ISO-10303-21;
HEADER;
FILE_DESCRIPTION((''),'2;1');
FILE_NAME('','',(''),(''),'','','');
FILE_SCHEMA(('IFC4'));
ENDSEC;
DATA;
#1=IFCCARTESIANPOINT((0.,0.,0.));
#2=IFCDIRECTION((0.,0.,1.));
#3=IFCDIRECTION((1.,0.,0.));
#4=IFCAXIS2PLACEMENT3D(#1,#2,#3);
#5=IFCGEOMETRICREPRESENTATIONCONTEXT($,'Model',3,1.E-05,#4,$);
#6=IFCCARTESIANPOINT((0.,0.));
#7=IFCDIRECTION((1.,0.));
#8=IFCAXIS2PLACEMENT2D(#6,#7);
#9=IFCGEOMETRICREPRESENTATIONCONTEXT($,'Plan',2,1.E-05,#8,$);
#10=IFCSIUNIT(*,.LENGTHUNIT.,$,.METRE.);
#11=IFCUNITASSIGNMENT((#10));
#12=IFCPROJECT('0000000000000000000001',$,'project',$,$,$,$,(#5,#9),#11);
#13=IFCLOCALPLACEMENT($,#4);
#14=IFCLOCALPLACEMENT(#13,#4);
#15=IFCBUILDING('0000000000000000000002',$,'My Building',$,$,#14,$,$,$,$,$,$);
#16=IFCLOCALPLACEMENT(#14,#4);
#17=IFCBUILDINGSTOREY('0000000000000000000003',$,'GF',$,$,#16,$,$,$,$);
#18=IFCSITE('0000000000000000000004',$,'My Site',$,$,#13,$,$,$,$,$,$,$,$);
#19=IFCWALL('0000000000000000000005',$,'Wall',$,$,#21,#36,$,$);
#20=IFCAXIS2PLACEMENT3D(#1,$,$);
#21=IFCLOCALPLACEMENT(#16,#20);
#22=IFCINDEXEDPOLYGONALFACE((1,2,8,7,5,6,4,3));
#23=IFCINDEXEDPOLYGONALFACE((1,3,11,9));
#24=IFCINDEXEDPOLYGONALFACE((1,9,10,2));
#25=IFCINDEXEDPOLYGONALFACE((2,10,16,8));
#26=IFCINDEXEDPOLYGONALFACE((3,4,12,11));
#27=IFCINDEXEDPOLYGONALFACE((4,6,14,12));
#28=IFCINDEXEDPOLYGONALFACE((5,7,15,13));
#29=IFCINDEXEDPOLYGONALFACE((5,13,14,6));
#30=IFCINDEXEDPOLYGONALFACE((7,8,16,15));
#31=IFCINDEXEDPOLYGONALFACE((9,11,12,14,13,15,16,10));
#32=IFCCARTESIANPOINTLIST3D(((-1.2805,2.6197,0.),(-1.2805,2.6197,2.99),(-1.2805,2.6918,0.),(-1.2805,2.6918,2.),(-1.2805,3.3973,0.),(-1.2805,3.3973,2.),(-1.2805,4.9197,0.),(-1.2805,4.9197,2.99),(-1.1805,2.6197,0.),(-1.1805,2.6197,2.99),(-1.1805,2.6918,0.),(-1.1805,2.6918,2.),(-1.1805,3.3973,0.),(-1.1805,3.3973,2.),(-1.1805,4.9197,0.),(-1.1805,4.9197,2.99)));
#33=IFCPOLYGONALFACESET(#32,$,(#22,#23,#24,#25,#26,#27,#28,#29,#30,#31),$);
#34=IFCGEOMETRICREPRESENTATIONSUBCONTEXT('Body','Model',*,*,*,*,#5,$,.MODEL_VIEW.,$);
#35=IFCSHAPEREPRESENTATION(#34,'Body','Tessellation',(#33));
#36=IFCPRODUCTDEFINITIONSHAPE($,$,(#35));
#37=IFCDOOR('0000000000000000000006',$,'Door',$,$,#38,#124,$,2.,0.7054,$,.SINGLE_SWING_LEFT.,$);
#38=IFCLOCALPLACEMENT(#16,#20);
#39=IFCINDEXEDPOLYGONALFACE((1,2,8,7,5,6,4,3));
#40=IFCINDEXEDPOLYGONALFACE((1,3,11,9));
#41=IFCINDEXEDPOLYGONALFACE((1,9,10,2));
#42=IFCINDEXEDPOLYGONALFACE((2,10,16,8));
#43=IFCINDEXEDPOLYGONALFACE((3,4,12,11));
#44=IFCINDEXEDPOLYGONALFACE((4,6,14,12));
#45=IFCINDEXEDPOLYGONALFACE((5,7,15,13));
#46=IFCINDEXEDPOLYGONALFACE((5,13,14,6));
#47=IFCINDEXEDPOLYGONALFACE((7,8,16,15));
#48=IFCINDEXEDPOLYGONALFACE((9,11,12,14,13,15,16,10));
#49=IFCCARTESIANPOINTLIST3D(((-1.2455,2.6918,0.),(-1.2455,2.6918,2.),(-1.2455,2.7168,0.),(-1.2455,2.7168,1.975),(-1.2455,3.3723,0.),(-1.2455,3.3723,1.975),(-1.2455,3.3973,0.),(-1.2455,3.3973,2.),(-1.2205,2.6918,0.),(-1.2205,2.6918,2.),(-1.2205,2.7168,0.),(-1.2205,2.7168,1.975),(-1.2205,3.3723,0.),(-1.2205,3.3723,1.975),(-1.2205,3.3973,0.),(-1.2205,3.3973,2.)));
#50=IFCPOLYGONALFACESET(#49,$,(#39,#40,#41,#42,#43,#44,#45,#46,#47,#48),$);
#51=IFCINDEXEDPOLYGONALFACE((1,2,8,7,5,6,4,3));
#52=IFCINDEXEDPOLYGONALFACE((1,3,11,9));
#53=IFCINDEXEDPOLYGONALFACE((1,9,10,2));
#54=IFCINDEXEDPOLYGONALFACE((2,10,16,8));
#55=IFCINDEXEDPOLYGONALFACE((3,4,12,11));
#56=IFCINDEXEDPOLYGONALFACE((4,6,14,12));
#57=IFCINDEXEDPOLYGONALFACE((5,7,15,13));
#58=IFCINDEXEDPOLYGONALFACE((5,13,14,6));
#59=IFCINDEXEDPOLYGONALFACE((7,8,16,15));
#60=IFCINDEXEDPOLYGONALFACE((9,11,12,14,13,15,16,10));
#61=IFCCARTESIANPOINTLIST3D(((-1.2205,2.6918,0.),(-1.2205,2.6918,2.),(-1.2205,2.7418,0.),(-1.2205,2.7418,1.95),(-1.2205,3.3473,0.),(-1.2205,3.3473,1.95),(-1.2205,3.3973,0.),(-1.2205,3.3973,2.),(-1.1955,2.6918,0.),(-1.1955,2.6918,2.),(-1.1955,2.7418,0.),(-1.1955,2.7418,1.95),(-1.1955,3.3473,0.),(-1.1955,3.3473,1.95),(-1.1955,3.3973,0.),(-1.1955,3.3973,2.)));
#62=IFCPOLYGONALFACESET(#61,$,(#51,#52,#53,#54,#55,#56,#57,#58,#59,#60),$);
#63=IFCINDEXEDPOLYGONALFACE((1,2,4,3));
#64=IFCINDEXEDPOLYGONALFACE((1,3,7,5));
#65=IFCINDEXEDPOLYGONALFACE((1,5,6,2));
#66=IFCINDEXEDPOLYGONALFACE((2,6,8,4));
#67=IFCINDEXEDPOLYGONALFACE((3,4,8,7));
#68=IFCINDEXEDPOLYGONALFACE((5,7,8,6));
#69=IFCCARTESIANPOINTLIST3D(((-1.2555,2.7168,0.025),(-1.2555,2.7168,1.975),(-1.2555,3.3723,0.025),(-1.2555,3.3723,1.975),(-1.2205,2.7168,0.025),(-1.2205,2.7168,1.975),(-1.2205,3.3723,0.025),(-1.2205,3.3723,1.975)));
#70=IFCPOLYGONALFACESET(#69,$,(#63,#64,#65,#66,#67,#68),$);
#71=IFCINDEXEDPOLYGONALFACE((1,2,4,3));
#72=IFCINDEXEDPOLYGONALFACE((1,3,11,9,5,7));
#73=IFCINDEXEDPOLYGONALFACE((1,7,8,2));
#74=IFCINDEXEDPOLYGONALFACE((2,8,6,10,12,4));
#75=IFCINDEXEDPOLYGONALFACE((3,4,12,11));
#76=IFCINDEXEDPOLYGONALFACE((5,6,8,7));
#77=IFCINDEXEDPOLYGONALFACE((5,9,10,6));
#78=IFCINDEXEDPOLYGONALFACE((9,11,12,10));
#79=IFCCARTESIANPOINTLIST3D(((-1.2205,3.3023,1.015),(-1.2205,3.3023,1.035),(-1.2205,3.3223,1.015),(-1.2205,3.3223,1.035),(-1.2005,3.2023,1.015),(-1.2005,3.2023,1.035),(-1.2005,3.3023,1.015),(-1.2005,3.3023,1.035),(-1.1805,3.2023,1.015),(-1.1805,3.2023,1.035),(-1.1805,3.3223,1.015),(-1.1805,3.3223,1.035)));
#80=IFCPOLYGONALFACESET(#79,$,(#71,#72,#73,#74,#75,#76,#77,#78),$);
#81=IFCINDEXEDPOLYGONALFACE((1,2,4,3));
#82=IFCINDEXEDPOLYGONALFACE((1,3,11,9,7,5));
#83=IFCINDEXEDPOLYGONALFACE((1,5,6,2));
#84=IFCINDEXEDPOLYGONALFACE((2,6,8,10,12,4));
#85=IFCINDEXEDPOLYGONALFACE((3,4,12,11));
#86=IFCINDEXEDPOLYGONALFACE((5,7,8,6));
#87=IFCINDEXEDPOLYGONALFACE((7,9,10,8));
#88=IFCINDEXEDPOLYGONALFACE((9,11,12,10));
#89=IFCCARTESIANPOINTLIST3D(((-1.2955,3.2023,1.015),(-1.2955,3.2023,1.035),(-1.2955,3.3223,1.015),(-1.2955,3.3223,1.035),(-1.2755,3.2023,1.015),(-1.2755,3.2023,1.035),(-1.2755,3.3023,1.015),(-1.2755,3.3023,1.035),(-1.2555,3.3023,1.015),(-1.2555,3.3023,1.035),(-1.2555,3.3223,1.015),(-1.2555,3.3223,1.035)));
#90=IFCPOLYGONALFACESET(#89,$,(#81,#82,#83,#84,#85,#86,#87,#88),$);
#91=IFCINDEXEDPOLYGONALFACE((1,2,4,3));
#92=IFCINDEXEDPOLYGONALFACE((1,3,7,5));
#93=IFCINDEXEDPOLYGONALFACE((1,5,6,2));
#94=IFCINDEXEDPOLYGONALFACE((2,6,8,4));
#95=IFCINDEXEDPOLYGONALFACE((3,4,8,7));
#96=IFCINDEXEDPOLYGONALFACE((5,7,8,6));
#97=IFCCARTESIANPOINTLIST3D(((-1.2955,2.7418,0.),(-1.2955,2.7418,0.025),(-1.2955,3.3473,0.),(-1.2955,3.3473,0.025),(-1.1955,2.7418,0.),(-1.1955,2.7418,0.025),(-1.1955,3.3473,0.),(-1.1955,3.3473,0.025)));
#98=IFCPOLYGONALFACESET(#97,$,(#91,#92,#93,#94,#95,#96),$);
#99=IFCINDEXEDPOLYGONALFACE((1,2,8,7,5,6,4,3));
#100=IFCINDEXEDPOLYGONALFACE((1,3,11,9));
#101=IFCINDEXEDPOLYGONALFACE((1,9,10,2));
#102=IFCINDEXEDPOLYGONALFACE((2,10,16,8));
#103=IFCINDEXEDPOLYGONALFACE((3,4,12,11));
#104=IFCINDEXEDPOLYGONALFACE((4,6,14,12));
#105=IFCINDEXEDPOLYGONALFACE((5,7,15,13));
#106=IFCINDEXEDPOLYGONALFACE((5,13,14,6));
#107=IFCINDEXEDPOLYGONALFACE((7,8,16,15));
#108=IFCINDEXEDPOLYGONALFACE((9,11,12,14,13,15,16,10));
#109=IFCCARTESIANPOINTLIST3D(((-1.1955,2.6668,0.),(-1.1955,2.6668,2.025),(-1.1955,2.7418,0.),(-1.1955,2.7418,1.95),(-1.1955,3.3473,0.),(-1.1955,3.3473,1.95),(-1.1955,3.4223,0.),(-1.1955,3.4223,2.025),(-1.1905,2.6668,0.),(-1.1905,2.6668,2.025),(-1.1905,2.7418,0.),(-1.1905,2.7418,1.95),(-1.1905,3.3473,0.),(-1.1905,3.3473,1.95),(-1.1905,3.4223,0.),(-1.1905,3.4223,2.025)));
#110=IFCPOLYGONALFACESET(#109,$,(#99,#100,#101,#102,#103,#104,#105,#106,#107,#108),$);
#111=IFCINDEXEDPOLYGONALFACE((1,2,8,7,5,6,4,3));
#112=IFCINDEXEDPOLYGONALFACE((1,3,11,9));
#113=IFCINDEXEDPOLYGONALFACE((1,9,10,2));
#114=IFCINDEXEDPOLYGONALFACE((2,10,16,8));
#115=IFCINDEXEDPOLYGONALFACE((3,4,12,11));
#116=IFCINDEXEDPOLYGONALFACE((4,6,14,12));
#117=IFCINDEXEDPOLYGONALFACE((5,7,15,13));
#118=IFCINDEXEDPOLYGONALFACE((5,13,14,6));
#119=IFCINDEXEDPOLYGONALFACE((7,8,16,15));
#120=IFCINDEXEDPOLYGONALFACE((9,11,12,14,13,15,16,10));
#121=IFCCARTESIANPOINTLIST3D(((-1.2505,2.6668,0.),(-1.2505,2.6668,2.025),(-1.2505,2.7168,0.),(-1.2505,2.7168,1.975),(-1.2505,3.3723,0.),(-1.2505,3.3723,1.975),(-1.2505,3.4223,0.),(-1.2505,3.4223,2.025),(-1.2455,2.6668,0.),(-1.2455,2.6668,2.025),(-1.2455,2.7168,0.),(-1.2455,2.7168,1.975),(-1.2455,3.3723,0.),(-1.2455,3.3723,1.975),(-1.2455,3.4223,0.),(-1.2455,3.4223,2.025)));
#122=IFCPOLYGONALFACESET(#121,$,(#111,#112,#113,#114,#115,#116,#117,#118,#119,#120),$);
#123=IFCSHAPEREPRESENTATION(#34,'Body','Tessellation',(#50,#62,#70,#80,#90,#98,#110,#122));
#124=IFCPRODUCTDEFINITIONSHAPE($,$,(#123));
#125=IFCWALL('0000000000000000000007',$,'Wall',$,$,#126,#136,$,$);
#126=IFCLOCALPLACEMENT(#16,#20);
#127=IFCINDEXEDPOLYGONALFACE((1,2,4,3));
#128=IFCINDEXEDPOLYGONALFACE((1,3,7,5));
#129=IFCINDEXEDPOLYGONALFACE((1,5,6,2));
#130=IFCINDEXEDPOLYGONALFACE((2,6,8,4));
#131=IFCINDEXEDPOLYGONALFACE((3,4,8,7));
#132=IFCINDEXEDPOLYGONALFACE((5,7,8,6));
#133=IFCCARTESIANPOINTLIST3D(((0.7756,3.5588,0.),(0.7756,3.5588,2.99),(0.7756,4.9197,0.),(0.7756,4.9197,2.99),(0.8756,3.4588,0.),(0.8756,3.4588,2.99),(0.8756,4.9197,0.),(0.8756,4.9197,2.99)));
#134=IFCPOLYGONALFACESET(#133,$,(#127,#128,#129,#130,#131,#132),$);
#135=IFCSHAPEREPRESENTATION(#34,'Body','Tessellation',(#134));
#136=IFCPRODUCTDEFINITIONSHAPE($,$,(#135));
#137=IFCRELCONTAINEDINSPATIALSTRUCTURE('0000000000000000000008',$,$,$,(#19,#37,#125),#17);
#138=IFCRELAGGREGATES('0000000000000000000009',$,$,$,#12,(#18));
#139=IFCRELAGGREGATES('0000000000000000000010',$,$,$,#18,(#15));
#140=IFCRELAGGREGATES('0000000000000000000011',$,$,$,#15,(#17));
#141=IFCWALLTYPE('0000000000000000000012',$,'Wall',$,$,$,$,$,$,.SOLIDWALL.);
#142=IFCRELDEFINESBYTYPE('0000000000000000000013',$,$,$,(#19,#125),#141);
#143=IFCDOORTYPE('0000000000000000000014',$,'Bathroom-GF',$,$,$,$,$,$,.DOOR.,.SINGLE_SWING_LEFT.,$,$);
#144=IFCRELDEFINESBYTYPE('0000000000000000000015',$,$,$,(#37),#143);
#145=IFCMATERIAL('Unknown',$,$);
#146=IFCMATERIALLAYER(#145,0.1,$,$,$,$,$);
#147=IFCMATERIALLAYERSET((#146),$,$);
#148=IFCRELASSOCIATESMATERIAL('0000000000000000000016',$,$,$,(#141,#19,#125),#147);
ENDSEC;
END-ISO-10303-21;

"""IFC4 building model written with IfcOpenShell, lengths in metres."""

from ifc_helpers import new_model, entity, si_unit, frame, origin_with_axes, origin_2d_with_axis, place, context, subcontext, project, spatial, line, indexed_curve, outline, extrude, shape, source, transform, mapped, material, layer, layer_set, layer_usage, type_object, type_shapes, element, fill, save


model = new_model("IFC4")

# Units and contexts
model_context = context("Model", 3, precision=1e-05, world=origin_with_axes())
plan_context = context("Plan", 2, precision=1e-05, world=origin_2d_with_axis())
body_context_1 = subcontext(model_context, "Body", "Model", "MODEL_VIEW")
body_context_2 = subcontext(plan_context, "Body", "Plan", "PLAN_VIEW")
ifc_project = project(units=[si_unit("LENGTHUNIT", "METRE")], contexts=[model_context, plan_context])

# Site, building, storey
site_placement = place(None, origin_with_axes())
site = spatial("IfcSite", under=ifc_project, at=site_placement, Name="My Site")
building_placement = place(site_placement, origin_with_axes())
building = spatial("IfcBuilding", under=site, at=building_placement, Name="My Building")
storey_placement = place(building_placement, origin_with_axes())
storey = spatial("IfcBuildingStorey", under=building, at=storey_placement, Name="GF")

# Shared definitions
ifc_material_1 = material(Name="Unknown")

# Shared definitions
ifc_layer_1 = layer(ifc_material_1, 0.1)
ifc_layer_set_1 = layer_set([ifc_layer_1])
wall_type = type_object("IfcWallType", Name="Wall", PredefinedType="SOLIDWALL", material=ifc_layer_set_1)

# Wall, opening, door
ifc_layer_usage_1 = layer_usage(ifc_layer_set_1, "AXIS2", "POSITIVE", 0.0)
wall_1_placement = place(storey_placement, frame((-1.1805, 2.6197, 0.0), z_axis=(0.0, 0.0, 1.0), x_axis=(0.0, 1.0, 0.0)))
wall_1 = element("IfcWall", 1, at=wall_1_placement, inside=storey, type_object=wall_type, material=ifc_layer_usage_1, Name="Wall", context=body_context_1, shape_type="SweptSolid", body=[
    extrude(outline(indexed_curve([(0.0, 0.0), (0.0, 0.1), (2.3, 0.1), (2.3, 0.0)], segments=[line(1, 2, 3, 4, 1)])), origin_with_axes(), (0.0, 0.0, 1.0), 2.99),
])
shared_shape_1 = source(origin_with_axes(), body_context_1, "Body", "SweptSolid", [
    extrude(outline(indexed_curve([(0.0, 0.0), (0.7054, 0.0), (0.7054, 2.0), (0.0, 2.0)], segments=[line(1, 2, 3, 4, 1)])), frame((0.0, -0.6, 0.0), z_axis=(0.0, -1.0, 0.0), x_axis=(1.0, 0.0, 0.0)), (0.0, 0.0, -1.0), 1.2),
])
opening_1_placement = place(wall_1_placement, frame((0.0721, 0.015, 0.0), z_axis=(0.0, 0.0, 1.0), x_axis=(1.0, 0.0, 0.0)))
opening_1 = element("IfcOpeningElement", 2, at=opening_1_placement, cuts=wall_1, PredefinedType="OPENING", context=body_context_1, shape_type="MappedRepresentation", body=[
    mapped(shared_shape_1, transform((0.0, 0.0, 0.0), x_axis=(1.0, 0.0, 0.0), y_axis=(0.0, 1.0, 0.0), z_axis=(0.0, 0.0, 1.0), scale=1.0)),
])
door_type_1 = type_object("IfcDoorType", Name="Bathroom-GF", OperationType="SINGLE_SWING_LEFT", PredefinedType="DOOR")
shared_shape_2 = source(origin_with_axes(), body_context_1, "Body", "SweptSolid", [
    extrude(outline(indexed_curve([(0.0, 0.0), (0.0, 2.0), (0.7054, 2.0), (0.7054, 0.0), (0.6804, 0.0), (0.6804, 1.975), (0.025, 1.975), (0.025, 0.0)], segments=[line(1, 2, 3, 4, 5, 6, 7, 8, 1)])), frame((0.0, 0.025, 0.0), z_axis=(0.0, -1.0, 0.0), x_axis=(1.0, 0.0, 0.0)), (0.0, 0.0, -1.0), 0.025),
    extrude(outline(indexed_curve([(0.0, 0.0), (0.0, 2.0), (0.7054, 2.0), (0.7054, 0.0), (0.6554, 0.0), (0.6554, 1.95), (0.05, 1.95), (0.05, 0.0)], segments=[line(1, 2, 3, 4, 5, 6, 7, 8, 1)])), frame((0.0, 0.0, 0.0), z_axis=(0.0, -1.0, 0.0), x_axis=(1.0, 0.0, 0.0)), (0.0, 0.0, -1.0), 0.025),
    extrude(outline(indexed_curve([(0.0, 0.0), (0.6554, 0.0), (0.6554, 0.035), (0.0, 0.035)], segments=[line(1, 2, 3, 4, 1)])), frame((0.025, 0.025, 0.025), z_axis=(0.0, 0.0, 1.0), x_axis=(1.0, 0.0, 0.0)), (0.0, 0.0, 1.0), 1.95),
    extrude(outline(indexed_curve([(0.0, 0.0), (0.0, -0.04), (-0.12, -0.04), (-0.12, -0.02), (-0.02, -0.02), (-0.02, 0.0)], segments=[line(1, 2, 3, 4, 5, 6, 1)])), frame((0.6304, 0.025, 1.015), z_axis=(0.0, 0.0, 1.0), x_axis=(1.0, 0.0, 0.0)), (0.0, 0.0, 1.0), 0.02),
    extrude(outline(indexed_curve([(0.0, 0.0), (0.0, 0.04), (-0.12, 0.04), (-0.12, 0.02), (-0.02, 0.02), (-0.02, 0.0)], segments=[line(1, 2, 3, 4, 5, 6, 1)])), frame((0.6304, 0.06, 1.015), z_axis=(0.0, 0.0, 1.0), x_axis=(1.0, 0.0, 0.0)), (0.0, 0.0, 1.0), 0.02),
    extrude(outline(indexed_curve([(0.0, 0.0), (0.6054, 0.0), (0.6054, 0.1), (0.0, 0.1)], segments=[line(1, 2, 3, 4, 1)])), frame((0.05, 0.0, 0.0), z_axis=(0.0, 0.0, 1.0), x_axis=(1.0, 0.0, 0.0)), (0.0, 0.0, 1.0), 0.025),
    extrude(outline(indexed_curve([(0.0, 0.0), (0.0, 2.025), (0.7554, 2.025), (0.7554, 0.0), (0.6804, 0.0), (0.6804, 1.95), (0.075, 1.95), (0.075, 0.0)], segments=[line(1, 2, 3, 4, 5, 6, 7, 8, 1)])), frame((-0.025, -0.005, 0.0), z_axis=(0.0, -1.0, 0.0), x_axis=(1.0, 0.0, 0.0)), (0.0, 0.0, -1.0), 0.005),
    extrude(outline(indexed_curve([(0.0, 0.0), (0.0, 2.025), (0.7554, 2.025), (0.7554, 0.0), (0.7054, 0.0), (0.7054, 1.975), (0.05, 1.975), (0.05, 0.0)], segments=[line(1, 2, 3, 4, 5, 6, 7, 8, 1)])), frame((-0.025, 0.05, 0.0), z_axis=(0.0, -1.0, 0.0), x_axis=(1.0, 0.0, 0.0)), (0.0, 0.0, -1.0), 0.005),
])
shared_shape_3 = source(origin_with_axes(), body_context_2, "Body", "Curve2D", [
    entity("IfcIndexedPolyCurve", entity("IfcCartesianPointList2D", [[0.0, 0.0], [0.0, 0.05], [0.025, 0.05], [0.025, 0.025], [0.05, 0.025], [0.05, 0.0]]), [entity("IfcLineIndex", [1, 2, 3, 4, 5, 6, 1])]),
    entity("IfcIndexedPolyCurve", entity("IfcCartesianPointList2D", [[0.7054, 0.0], [0.7054, 0.05], [0.6804, 0.05], [0.6804, 0.025], [0.6554, 0.025], [0.6554, 0.0]]), [entity("IfcLineIndex", [1, 2, 3, 4, 5, 6, 1])]),
    entity("IfcTrimmedCurve", entity("IfcEllipse", entity("IfcAxis2Placement2D", entity("IfcCartesianPoint", [0.06, 0.05]), entity("IfcDirection", [1.0, 0.0])), 0.6204, 0.6554), [entity("IfcCartesianPoint", [0.6804, 0.05])], [entity("IfcCartesianPoint", [0.06, 0.7054])], True, "CARTESIAN"),
    entity("IfcIndexedPolyCurve", entity("IfcCartesianPointList2D", [[0.025, 0.05], [0.06, 0.05], [0.06, 0.7054], [0.025, 0.7054]]), [entity("IfcLineIndex", [1, 2, 3, 4, 1])]),
])
type_shapes(door_type_1, [shared_shape_2, shared_shape_3])
door_1_placement = place(opening_1_placement, frame((0.0, 0.0, 0.0), z_axis=(0.0, 0.0, 1.0), x_axis=(1.0, 0.0, 0.0)))
door_1 = element("IfcDoor", 3, at=door_1_placement, inside=storey, type_object=door_type_1, Name="Door", OperationType="SINGLE_SWING_LEFT", OverallHeight=2.0, OverallWidth=0.7054, shapes=[
    shape(body_context_1, "Body", "MappedRepresentation", [mapped(shared_shape_2, transform((0.0, 0.0, 0.0), x_axis=(1.0, 0.0, 0.0), y_axis=(0.0, 1.0, 0.0), z_axis=(0.0, 0.0, 1.0), scale=1.0))]),
    shape(body_context_2, "Body", "MappedRepresentation", [mapped(shared_shape_3, transform((0.0, 0.0, 0.0), x_axis=(1.0, 0.0, 0.0), y_axis=(0.0, 1.0, 0.0), z_axis=(0.0, 0.0, 1.0), scale=1.0))]),
])
fill(opening_1, door_1)

# Wall
ifc_layer_usage_2 = layer_usage(ifc_layer_set_1, "AXIS2", "POSITIVE", 0.0)
wall_2_placement = place(storey_placement, frame((0.7756, 5.0197, 0.0), z_axis=(0.0, 0.0, 1.0), x_axis=(0.0, -1.0, 0.0)))
element("IfcWall", 4, at=wall_2_placement, inside=storey, type_object=wall_type, material=ifc_layer_usage_2, Name="Wall", context=body_context_1, shape_type="SweptSolid", body=[
    extrude(outline(indexed_curve([(0.1, 0.0), (0.1, 0.1), (1.561, 0.1), (1.461, 0.0)], segments=[line(1, 2, 3, 4, 1)])), origin_with_axes(), (0.0, 0.0, 1.0), 2.99),
])

save(model, "model.ifc")
